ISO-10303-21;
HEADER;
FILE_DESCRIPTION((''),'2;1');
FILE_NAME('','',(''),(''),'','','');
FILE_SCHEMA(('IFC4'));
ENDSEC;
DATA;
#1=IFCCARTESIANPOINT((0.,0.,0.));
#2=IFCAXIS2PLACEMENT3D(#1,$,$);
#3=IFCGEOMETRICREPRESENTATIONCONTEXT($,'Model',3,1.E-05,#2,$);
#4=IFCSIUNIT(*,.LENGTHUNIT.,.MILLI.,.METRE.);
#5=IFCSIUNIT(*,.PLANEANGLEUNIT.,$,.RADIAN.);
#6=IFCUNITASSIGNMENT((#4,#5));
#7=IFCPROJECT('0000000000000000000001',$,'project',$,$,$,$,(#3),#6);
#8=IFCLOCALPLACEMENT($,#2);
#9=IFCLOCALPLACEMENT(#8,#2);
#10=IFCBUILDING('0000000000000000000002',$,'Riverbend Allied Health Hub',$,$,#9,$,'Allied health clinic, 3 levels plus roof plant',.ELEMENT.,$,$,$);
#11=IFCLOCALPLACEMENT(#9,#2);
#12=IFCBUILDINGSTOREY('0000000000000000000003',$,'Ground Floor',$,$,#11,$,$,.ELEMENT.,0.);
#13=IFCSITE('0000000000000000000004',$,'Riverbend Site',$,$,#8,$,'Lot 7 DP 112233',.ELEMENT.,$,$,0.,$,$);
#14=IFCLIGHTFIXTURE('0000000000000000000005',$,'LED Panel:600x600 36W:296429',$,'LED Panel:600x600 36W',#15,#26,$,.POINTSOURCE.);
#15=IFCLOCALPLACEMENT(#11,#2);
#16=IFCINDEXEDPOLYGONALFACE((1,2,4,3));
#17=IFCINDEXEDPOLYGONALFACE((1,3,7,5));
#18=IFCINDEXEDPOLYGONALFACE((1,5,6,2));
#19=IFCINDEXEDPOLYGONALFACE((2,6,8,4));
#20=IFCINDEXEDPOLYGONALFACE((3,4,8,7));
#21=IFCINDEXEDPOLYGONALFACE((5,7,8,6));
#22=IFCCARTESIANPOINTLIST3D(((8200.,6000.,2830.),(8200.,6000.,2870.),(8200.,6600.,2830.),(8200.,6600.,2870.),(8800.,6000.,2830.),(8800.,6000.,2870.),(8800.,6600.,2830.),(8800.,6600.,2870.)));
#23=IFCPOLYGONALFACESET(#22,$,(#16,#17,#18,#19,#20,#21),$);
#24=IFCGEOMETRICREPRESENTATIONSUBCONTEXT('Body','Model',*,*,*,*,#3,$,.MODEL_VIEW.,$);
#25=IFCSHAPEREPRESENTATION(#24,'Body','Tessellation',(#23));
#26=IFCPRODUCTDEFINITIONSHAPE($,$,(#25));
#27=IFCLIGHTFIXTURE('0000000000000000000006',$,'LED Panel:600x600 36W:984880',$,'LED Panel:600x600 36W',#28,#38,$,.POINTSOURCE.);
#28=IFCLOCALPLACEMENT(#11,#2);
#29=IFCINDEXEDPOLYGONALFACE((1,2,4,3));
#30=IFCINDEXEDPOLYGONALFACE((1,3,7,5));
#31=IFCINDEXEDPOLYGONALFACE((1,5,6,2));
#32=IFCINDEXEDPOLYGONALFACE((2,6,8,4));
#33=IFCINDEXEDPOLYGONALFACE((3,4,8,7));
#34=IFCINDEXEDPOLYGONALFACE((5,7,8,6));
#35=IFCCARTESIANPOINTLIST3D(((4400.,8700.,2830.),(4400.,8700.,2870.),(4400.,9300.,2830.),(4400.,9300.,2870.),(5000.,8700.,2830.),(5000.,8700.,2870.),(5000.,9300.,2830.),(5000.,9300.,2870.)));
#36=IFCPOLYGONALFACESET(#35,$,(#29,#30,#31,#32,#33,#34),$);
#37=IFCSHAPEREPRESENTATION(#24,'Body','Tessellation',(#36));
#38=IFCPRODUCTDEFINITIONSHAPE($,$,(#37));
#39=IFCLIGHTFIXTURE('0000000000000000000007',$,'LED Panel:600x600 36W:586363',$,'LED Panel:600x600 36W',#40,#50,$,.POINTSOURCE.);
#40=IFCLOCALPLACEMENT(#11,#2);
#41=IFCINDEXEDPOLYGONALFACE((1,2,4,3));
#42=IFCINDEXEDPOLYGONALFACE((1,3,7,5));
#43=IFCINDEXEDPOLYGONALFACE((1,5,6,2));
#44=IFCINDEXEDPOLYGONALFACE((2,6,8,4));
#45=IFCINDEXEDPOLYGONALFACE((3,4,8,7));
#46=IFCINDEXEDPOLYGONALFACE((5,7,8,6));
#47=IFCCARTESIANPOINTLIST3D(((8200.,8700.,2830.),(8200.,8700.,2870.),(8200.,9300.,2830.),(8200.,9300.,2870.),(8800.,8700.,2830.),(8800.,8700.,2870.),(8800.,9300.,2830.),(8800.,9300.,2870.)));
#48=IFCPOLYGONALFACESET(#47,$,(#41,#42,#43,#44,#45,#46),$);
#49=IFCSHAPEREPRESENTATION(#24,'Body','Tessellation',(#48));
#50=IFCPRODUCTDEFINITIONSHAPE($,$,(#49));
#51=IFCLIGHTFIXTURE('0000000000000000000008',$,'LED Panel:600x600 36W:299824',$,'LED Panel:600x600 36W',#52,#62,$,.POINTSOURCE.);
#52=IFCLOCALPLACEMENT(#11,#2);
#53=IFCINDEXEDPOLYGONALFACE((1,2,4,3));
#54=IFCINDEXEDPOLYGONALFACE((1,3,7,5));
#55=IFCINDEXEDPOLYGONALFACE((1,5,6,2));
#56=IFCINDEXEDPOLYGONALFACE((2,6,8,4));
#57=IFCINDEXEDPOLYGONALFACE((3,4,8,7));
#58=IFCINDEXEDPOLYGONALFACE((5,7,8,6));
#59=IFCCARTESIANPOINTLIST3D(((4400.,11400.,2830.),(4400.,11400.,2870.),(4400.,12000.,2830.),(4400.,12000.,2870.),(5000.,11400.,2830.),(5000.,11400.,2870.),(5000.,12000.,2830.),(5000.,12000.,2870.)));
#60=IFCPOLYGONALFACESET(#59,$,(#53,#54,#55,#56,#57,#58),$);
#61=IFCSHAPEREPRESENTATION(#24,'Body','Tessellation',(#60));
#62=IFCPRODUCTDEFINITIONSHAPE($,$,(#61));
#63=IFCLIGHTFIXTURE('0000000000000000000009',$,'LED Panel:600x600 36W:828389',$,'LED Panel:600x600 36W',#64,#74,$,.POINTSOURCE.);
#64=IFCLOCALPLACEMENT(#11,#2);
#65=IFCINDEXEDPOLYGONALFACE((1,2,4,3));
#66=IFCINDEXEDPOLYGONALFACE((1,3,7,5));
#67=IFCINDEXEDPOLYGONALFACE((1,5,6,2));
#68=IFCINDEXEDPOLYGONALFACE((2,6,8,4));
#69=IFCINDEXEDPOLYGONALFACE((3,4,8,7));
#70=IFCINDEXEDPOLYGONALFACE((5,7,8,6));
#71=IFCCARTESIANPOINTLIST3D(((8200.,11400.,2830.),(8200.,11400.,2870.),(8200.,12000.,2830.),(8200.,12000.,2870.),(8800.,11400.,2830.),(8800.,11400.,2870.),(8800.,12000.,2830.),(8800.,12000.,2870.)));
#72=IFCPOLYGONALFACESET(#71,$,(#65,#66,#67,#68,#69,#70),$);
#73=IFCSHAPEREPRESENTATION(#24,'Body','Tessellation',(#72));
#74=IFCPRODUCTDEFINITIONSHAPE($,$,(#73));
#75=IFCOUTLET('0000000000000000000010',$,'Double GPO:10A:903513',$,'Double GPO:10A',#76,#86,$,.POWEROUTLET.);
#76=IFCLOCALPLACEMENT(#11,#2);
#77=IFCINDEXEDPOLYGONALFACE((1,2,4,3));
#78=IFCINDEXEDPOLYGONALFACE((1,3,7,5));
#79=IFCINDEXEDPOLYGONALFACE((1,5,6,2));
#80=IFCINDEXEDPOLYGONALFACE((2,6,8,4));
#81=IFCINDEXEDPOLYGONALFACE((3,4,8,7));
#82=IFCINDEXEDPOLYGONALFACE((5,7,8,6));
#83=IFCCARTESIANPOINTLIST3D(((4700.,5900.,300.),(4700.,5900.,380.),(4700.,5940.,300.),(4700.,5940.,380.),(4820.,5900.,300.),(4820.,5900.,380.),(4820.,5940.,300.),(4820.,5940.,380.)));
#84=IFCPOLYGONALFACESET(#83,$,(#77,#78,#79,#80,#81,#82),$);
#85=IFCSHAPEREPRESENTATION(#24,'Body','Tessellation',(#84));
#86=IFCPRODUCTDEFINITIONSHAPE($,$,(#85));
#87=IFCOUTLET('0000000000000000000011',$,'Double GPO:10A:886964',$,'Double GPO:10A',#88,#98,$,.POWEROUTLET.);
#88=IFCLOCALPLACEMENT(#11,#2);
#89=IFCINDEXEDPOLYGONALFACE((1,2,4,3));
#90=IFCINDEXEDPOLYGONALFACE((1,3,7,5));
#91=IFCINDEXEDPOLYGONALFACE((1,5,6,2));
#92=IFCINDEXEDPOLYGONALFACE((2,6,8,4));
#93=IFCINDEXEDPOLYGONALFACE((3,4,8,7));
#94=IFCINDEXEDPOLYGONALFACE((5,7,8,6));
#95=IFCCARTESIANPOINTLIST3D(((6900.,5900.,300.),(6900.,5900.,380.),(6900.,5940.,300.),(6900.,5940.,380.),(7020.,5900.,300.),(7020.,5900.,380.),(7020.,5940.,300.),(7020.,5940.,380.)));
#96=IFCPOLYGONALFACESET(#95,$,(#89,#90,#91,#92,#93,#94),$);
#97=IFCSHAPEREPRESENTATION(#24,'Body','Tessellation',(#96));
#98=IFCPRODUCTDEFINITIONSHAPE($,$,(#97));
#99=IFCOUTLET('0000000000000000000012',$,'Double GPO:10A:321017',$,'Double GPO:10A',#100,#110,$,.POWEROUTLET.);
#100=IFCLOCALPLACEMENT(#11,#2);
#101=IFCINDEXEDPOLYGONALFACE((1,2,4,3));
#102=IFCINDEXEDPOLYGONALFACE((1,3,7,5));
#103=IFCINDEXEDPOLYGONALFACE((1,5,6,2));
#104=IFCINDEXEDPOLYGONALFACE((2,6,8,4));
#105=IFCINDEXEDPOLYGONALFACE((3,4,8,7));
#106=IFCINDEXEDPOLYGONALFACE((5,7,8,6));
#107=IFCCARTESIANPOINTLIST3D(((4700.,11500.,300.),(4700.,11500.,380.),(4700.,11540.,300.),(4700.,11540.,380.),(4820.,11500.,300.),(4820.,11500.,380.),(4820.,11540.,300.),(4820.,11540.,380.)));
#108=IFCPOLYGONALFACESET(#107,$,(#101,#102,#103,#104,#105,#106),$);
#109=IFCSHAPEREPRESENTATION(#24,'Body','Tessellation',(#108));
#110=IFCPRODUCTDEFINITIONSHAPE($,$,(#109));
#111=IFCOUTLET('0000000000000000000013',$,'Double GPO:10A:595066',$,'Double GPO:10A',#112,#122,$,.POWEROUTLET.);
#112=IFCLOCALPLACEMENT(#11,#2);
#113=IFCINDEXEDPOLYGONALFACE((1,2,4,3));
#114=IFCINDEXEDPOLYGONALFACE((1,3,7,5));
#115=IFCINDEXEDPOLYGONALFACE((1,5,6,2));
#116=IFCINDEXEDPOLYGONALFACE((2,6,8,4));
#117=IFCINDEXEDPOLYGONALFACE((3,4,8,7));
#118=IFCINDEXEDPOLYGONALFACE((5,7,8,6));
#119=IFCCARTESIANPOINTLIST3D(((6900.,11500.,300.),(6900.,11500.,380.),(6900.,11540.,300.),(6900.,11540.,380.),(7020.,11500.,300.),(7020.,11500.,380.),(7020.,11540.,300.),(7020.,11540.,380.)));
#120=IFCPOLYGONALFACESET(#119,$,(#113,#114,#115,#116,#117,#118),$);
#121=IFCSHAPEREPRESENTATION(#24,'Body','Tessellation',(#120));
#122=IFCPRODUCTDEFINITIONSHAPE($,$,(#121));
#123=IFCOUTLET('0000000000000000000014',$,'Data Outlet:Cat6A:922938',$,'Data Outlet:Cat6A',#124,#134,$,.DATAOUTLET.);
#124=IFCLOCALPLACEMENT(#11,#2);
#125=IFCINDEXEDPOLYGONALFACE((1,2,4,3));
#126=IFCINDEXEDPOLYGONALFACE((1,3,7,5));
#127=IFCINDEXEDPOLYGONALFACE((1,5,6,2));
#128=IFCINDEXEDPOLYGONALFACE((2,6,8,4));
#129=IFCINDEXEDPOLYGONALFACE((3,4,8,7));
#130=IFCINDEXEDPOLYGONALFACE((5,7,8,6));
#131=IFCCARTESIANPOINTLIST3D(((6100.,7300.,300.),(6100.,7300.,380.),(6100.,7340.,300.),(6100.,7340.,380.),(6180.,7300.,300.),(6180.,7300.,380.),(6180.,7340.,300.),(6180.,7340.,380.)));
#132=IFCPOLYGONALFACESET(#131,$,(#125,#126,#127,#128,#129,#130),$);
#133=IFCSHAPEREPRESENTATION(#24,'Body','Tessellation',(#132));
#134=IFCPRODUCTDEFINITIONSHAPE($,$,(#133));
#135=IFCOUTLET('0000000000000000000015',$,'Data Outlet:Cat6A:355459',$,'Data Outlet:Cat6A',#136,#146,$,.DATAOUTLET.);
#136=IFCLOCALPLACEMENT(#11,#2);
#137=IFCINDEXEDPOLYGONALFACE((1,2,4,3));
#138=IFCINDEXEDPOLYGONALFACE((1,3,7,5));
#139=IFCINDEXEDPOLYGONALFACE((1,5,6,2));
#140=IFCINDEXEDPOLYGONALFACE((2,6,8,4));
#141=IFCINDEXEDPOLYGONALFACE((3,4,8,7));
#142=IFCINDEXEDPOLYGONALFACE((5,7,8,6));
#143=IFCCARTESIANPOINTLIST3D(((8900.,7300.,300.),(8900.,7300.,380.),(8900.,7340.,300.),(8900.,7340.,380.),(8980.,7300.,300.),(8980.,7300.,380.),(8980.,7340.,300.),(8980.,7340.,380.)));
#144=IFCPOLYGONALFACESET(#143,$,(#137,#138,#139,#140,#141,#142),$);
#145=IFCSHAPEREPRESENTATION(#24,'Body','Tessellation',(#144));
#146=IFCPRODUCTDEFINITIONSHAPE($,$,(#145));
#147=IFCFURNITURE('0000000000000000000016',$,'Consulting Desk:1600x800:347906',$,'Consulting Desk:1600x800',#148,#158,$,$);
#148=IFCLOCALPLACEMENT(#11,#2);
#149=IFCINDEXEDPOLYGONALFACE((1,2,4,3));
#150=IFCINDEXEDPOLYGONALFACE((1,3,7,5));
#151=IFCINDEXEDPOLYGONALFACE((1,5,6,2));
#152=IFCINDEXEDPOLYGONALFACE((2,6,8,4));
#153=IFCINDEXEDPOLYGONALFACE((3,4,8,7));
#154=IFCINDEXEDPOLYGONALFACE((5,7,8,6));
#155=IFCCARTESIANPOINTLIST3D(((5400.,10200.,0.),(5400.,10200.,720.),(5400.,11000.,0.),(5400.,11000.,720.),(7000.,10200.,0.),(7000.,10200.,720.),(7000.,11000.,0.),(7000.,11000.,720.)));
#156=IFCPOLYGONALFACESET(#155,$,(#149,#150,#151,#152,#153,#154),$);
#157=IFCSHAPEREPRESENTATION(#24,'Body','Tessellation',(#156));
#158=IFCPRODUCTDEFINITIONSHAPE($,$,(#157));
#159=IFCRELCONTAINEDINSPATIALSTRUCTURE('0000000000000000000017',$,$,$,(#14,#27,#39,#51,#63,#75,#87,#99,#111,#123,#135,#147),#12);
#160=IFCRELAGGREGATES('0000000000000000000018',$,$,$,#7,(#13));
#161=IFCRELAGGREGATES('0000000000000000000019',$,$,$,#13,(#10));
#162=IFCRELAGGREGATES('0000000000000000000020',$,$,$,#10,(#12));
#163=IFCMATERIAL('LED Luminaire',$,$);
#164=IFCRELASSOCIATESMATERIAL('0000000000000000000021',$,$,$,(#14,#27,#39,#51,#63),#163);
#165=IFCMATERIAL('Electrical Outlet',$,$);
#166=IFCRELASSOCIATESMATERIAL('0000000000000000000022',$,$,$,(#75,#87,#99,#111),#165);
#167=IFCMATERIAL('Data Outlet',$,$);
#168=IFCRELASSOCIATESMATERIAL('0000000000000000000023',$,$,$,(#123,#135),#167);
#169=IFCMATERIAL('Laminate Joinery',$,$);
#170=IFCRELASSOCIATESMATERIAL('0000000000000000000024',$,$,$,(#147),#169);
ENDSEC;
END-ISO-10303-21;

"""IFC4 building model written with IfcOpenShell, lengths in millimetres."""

from ifc_helpers import new_model, si_unit, frame, frame_2d, origin, place, context, subcontext, project, spatial, rectangle, extrude, material, element, save


model = new_model("IFC4")

# Units and contexts
model_context = context("Model", 3, precision=1e-05, world=origin())
body_context = subcontext(model_context, "Body", "Model", "MODEL_VIEW")
ifc_project = project(units=[si_unit("LENGTHUNIT", "METRE", prefix="MILLI"), si_unit("PLANEANGLEUNIT", "RADIAN")], contexts=[model_context])

# Site, building, storey
site_placement = place(None, origin())
site = spatial("IfcSite", under=ifc_project, at=site_placement, Name="Riverbend Site", LongName="Lot 7 DP 112233", CompositionType="ELEMENT", RefElevation=0.0)
building_placement = place(site_placement, origin())
building = spatial("IfcBuilding", under=site, at=building_placement, Name="Riverbend Allied Health Hub", LongName="Allied health clinic, 3 levels plus roof plant", CompositionType="ELEMENT")
storey_placement = place(building_placement, origin())
storey = spatial("IfcBuildingStorey", under=building, at=storey_placement, Name="Ground Floor", CompositionType="ELEMENT", Elevation=0.0)

# Light fixtures
ifc_material_1 = material(Name="LED Luminaire")
for number, where, name in (
    (1, (8200.0, 6000.0, 2830.0), "LED Panel:600x600 36W:296429"),
    (2, (4400.0, 8700.0, 2830.0), "LED Panel:600x600 36W:984880"),
    (3, (8200.0, 8700.0, 2830.0), "LED Panel:600x600 36W:586363"),
    (4, (4400.0, 11400.0, 2830.0), "LED Panel:600x600 36W:299824"),
    (5, (8200.0, 11400.0, 2830.0), "LED Panel:600x600 36W:828389"),
):
    element("IfcLightFixture", number, at=place(storey_placement, frame(where)), inside=storey, material=ifc_material_1, Name=name, ObjectType="LED Panel:600x600 36W", PredefinedType="POINTSOURCE", context=body_context, shape_type="SweptSolid", body=[
        extrude(rectangle(XDim=600.0, YDim=600.0, at=frame_2d((300.0, 300.0))), origin(), (0.0, 0.0, 1.0), 40.0),
    ])

# Outlets
ifc_material_2 = material(Name="Electrical Outlet")
for number, where, name in (
    (6, (4700.0, 5900.0, 300.0), "Double GPO:10A:903513"),
    (7, (6900.0, 5900.0, 300.0), "Double GPO:10A:886964"),
    (8, (4700.0, 11500.0, 300.0), "Double GPO:10A:321017"),
    (9, (6900.0, 11500.0, 300.0), "Double GPO:10A:595066"),
):
    element("IfcOutlet", number, at=place(storey_placement, frame(where)), inside=storey, material=ifc_material_2, Name=name, ObjectType="Double GPO:10A", PredefinedType="POWEROUTLET", context=body_context, shape_type="SweptSolid", body=[
        extrude(rectangle(XDim=120.0, YDim=40.0, at=frame_2d((60.0, 20.0))), origin(), (0.0, 0.0, 1.0), 80.0),
    ])
ifc_material_3 = material(Name="Data Outlet")
for number, where, name in (
    (10, (6100.0, 7300.0, 300.0), "Data Outlet:Cat6A:922938"),
    (11, (8900.0, 7300.0, 300.0), "Data Outlet:Cat6A:355459"),
):
    element("IfcOutlet", number, at=place(storey_placement, frame(where)), inside=storey, material=ifc_material_3, Name=name, ObjectType="Data Outlet:Cat6A", PredefinedType="DATAOUTLET", context=body_context, shape_type="SweptSolid", body=[
        extrude(rectangle(XDim=80.0, YDim=40.0, at=frame_2d((40.0, 20.0))), origin(), (0.0, 0.0, 1.0), 80.0),
    ])

# Furniture
ifc_material_4 = material(Name="Laminate Joinery")
furniture_placement = place(storey_placement, frame((5400.0, 10200.0, 0.0)))
element("IfcFurniture", 12, at=furniture_placement, inside=storey, material=ifc_material_4, Name="Consulting Desk:1600x800:347906", ObjectType="Consulting Desk:1600x800", context=body_context, shape_type="SweptSolid", body=[
    extrude(rectangle(XDim=1600.0, YDim=800.0, at=frame_2d((800.0, 400.0))), origin(), (0.0, 0.0, 1.0), 720.0),
])

save(model, "model.ifc")
